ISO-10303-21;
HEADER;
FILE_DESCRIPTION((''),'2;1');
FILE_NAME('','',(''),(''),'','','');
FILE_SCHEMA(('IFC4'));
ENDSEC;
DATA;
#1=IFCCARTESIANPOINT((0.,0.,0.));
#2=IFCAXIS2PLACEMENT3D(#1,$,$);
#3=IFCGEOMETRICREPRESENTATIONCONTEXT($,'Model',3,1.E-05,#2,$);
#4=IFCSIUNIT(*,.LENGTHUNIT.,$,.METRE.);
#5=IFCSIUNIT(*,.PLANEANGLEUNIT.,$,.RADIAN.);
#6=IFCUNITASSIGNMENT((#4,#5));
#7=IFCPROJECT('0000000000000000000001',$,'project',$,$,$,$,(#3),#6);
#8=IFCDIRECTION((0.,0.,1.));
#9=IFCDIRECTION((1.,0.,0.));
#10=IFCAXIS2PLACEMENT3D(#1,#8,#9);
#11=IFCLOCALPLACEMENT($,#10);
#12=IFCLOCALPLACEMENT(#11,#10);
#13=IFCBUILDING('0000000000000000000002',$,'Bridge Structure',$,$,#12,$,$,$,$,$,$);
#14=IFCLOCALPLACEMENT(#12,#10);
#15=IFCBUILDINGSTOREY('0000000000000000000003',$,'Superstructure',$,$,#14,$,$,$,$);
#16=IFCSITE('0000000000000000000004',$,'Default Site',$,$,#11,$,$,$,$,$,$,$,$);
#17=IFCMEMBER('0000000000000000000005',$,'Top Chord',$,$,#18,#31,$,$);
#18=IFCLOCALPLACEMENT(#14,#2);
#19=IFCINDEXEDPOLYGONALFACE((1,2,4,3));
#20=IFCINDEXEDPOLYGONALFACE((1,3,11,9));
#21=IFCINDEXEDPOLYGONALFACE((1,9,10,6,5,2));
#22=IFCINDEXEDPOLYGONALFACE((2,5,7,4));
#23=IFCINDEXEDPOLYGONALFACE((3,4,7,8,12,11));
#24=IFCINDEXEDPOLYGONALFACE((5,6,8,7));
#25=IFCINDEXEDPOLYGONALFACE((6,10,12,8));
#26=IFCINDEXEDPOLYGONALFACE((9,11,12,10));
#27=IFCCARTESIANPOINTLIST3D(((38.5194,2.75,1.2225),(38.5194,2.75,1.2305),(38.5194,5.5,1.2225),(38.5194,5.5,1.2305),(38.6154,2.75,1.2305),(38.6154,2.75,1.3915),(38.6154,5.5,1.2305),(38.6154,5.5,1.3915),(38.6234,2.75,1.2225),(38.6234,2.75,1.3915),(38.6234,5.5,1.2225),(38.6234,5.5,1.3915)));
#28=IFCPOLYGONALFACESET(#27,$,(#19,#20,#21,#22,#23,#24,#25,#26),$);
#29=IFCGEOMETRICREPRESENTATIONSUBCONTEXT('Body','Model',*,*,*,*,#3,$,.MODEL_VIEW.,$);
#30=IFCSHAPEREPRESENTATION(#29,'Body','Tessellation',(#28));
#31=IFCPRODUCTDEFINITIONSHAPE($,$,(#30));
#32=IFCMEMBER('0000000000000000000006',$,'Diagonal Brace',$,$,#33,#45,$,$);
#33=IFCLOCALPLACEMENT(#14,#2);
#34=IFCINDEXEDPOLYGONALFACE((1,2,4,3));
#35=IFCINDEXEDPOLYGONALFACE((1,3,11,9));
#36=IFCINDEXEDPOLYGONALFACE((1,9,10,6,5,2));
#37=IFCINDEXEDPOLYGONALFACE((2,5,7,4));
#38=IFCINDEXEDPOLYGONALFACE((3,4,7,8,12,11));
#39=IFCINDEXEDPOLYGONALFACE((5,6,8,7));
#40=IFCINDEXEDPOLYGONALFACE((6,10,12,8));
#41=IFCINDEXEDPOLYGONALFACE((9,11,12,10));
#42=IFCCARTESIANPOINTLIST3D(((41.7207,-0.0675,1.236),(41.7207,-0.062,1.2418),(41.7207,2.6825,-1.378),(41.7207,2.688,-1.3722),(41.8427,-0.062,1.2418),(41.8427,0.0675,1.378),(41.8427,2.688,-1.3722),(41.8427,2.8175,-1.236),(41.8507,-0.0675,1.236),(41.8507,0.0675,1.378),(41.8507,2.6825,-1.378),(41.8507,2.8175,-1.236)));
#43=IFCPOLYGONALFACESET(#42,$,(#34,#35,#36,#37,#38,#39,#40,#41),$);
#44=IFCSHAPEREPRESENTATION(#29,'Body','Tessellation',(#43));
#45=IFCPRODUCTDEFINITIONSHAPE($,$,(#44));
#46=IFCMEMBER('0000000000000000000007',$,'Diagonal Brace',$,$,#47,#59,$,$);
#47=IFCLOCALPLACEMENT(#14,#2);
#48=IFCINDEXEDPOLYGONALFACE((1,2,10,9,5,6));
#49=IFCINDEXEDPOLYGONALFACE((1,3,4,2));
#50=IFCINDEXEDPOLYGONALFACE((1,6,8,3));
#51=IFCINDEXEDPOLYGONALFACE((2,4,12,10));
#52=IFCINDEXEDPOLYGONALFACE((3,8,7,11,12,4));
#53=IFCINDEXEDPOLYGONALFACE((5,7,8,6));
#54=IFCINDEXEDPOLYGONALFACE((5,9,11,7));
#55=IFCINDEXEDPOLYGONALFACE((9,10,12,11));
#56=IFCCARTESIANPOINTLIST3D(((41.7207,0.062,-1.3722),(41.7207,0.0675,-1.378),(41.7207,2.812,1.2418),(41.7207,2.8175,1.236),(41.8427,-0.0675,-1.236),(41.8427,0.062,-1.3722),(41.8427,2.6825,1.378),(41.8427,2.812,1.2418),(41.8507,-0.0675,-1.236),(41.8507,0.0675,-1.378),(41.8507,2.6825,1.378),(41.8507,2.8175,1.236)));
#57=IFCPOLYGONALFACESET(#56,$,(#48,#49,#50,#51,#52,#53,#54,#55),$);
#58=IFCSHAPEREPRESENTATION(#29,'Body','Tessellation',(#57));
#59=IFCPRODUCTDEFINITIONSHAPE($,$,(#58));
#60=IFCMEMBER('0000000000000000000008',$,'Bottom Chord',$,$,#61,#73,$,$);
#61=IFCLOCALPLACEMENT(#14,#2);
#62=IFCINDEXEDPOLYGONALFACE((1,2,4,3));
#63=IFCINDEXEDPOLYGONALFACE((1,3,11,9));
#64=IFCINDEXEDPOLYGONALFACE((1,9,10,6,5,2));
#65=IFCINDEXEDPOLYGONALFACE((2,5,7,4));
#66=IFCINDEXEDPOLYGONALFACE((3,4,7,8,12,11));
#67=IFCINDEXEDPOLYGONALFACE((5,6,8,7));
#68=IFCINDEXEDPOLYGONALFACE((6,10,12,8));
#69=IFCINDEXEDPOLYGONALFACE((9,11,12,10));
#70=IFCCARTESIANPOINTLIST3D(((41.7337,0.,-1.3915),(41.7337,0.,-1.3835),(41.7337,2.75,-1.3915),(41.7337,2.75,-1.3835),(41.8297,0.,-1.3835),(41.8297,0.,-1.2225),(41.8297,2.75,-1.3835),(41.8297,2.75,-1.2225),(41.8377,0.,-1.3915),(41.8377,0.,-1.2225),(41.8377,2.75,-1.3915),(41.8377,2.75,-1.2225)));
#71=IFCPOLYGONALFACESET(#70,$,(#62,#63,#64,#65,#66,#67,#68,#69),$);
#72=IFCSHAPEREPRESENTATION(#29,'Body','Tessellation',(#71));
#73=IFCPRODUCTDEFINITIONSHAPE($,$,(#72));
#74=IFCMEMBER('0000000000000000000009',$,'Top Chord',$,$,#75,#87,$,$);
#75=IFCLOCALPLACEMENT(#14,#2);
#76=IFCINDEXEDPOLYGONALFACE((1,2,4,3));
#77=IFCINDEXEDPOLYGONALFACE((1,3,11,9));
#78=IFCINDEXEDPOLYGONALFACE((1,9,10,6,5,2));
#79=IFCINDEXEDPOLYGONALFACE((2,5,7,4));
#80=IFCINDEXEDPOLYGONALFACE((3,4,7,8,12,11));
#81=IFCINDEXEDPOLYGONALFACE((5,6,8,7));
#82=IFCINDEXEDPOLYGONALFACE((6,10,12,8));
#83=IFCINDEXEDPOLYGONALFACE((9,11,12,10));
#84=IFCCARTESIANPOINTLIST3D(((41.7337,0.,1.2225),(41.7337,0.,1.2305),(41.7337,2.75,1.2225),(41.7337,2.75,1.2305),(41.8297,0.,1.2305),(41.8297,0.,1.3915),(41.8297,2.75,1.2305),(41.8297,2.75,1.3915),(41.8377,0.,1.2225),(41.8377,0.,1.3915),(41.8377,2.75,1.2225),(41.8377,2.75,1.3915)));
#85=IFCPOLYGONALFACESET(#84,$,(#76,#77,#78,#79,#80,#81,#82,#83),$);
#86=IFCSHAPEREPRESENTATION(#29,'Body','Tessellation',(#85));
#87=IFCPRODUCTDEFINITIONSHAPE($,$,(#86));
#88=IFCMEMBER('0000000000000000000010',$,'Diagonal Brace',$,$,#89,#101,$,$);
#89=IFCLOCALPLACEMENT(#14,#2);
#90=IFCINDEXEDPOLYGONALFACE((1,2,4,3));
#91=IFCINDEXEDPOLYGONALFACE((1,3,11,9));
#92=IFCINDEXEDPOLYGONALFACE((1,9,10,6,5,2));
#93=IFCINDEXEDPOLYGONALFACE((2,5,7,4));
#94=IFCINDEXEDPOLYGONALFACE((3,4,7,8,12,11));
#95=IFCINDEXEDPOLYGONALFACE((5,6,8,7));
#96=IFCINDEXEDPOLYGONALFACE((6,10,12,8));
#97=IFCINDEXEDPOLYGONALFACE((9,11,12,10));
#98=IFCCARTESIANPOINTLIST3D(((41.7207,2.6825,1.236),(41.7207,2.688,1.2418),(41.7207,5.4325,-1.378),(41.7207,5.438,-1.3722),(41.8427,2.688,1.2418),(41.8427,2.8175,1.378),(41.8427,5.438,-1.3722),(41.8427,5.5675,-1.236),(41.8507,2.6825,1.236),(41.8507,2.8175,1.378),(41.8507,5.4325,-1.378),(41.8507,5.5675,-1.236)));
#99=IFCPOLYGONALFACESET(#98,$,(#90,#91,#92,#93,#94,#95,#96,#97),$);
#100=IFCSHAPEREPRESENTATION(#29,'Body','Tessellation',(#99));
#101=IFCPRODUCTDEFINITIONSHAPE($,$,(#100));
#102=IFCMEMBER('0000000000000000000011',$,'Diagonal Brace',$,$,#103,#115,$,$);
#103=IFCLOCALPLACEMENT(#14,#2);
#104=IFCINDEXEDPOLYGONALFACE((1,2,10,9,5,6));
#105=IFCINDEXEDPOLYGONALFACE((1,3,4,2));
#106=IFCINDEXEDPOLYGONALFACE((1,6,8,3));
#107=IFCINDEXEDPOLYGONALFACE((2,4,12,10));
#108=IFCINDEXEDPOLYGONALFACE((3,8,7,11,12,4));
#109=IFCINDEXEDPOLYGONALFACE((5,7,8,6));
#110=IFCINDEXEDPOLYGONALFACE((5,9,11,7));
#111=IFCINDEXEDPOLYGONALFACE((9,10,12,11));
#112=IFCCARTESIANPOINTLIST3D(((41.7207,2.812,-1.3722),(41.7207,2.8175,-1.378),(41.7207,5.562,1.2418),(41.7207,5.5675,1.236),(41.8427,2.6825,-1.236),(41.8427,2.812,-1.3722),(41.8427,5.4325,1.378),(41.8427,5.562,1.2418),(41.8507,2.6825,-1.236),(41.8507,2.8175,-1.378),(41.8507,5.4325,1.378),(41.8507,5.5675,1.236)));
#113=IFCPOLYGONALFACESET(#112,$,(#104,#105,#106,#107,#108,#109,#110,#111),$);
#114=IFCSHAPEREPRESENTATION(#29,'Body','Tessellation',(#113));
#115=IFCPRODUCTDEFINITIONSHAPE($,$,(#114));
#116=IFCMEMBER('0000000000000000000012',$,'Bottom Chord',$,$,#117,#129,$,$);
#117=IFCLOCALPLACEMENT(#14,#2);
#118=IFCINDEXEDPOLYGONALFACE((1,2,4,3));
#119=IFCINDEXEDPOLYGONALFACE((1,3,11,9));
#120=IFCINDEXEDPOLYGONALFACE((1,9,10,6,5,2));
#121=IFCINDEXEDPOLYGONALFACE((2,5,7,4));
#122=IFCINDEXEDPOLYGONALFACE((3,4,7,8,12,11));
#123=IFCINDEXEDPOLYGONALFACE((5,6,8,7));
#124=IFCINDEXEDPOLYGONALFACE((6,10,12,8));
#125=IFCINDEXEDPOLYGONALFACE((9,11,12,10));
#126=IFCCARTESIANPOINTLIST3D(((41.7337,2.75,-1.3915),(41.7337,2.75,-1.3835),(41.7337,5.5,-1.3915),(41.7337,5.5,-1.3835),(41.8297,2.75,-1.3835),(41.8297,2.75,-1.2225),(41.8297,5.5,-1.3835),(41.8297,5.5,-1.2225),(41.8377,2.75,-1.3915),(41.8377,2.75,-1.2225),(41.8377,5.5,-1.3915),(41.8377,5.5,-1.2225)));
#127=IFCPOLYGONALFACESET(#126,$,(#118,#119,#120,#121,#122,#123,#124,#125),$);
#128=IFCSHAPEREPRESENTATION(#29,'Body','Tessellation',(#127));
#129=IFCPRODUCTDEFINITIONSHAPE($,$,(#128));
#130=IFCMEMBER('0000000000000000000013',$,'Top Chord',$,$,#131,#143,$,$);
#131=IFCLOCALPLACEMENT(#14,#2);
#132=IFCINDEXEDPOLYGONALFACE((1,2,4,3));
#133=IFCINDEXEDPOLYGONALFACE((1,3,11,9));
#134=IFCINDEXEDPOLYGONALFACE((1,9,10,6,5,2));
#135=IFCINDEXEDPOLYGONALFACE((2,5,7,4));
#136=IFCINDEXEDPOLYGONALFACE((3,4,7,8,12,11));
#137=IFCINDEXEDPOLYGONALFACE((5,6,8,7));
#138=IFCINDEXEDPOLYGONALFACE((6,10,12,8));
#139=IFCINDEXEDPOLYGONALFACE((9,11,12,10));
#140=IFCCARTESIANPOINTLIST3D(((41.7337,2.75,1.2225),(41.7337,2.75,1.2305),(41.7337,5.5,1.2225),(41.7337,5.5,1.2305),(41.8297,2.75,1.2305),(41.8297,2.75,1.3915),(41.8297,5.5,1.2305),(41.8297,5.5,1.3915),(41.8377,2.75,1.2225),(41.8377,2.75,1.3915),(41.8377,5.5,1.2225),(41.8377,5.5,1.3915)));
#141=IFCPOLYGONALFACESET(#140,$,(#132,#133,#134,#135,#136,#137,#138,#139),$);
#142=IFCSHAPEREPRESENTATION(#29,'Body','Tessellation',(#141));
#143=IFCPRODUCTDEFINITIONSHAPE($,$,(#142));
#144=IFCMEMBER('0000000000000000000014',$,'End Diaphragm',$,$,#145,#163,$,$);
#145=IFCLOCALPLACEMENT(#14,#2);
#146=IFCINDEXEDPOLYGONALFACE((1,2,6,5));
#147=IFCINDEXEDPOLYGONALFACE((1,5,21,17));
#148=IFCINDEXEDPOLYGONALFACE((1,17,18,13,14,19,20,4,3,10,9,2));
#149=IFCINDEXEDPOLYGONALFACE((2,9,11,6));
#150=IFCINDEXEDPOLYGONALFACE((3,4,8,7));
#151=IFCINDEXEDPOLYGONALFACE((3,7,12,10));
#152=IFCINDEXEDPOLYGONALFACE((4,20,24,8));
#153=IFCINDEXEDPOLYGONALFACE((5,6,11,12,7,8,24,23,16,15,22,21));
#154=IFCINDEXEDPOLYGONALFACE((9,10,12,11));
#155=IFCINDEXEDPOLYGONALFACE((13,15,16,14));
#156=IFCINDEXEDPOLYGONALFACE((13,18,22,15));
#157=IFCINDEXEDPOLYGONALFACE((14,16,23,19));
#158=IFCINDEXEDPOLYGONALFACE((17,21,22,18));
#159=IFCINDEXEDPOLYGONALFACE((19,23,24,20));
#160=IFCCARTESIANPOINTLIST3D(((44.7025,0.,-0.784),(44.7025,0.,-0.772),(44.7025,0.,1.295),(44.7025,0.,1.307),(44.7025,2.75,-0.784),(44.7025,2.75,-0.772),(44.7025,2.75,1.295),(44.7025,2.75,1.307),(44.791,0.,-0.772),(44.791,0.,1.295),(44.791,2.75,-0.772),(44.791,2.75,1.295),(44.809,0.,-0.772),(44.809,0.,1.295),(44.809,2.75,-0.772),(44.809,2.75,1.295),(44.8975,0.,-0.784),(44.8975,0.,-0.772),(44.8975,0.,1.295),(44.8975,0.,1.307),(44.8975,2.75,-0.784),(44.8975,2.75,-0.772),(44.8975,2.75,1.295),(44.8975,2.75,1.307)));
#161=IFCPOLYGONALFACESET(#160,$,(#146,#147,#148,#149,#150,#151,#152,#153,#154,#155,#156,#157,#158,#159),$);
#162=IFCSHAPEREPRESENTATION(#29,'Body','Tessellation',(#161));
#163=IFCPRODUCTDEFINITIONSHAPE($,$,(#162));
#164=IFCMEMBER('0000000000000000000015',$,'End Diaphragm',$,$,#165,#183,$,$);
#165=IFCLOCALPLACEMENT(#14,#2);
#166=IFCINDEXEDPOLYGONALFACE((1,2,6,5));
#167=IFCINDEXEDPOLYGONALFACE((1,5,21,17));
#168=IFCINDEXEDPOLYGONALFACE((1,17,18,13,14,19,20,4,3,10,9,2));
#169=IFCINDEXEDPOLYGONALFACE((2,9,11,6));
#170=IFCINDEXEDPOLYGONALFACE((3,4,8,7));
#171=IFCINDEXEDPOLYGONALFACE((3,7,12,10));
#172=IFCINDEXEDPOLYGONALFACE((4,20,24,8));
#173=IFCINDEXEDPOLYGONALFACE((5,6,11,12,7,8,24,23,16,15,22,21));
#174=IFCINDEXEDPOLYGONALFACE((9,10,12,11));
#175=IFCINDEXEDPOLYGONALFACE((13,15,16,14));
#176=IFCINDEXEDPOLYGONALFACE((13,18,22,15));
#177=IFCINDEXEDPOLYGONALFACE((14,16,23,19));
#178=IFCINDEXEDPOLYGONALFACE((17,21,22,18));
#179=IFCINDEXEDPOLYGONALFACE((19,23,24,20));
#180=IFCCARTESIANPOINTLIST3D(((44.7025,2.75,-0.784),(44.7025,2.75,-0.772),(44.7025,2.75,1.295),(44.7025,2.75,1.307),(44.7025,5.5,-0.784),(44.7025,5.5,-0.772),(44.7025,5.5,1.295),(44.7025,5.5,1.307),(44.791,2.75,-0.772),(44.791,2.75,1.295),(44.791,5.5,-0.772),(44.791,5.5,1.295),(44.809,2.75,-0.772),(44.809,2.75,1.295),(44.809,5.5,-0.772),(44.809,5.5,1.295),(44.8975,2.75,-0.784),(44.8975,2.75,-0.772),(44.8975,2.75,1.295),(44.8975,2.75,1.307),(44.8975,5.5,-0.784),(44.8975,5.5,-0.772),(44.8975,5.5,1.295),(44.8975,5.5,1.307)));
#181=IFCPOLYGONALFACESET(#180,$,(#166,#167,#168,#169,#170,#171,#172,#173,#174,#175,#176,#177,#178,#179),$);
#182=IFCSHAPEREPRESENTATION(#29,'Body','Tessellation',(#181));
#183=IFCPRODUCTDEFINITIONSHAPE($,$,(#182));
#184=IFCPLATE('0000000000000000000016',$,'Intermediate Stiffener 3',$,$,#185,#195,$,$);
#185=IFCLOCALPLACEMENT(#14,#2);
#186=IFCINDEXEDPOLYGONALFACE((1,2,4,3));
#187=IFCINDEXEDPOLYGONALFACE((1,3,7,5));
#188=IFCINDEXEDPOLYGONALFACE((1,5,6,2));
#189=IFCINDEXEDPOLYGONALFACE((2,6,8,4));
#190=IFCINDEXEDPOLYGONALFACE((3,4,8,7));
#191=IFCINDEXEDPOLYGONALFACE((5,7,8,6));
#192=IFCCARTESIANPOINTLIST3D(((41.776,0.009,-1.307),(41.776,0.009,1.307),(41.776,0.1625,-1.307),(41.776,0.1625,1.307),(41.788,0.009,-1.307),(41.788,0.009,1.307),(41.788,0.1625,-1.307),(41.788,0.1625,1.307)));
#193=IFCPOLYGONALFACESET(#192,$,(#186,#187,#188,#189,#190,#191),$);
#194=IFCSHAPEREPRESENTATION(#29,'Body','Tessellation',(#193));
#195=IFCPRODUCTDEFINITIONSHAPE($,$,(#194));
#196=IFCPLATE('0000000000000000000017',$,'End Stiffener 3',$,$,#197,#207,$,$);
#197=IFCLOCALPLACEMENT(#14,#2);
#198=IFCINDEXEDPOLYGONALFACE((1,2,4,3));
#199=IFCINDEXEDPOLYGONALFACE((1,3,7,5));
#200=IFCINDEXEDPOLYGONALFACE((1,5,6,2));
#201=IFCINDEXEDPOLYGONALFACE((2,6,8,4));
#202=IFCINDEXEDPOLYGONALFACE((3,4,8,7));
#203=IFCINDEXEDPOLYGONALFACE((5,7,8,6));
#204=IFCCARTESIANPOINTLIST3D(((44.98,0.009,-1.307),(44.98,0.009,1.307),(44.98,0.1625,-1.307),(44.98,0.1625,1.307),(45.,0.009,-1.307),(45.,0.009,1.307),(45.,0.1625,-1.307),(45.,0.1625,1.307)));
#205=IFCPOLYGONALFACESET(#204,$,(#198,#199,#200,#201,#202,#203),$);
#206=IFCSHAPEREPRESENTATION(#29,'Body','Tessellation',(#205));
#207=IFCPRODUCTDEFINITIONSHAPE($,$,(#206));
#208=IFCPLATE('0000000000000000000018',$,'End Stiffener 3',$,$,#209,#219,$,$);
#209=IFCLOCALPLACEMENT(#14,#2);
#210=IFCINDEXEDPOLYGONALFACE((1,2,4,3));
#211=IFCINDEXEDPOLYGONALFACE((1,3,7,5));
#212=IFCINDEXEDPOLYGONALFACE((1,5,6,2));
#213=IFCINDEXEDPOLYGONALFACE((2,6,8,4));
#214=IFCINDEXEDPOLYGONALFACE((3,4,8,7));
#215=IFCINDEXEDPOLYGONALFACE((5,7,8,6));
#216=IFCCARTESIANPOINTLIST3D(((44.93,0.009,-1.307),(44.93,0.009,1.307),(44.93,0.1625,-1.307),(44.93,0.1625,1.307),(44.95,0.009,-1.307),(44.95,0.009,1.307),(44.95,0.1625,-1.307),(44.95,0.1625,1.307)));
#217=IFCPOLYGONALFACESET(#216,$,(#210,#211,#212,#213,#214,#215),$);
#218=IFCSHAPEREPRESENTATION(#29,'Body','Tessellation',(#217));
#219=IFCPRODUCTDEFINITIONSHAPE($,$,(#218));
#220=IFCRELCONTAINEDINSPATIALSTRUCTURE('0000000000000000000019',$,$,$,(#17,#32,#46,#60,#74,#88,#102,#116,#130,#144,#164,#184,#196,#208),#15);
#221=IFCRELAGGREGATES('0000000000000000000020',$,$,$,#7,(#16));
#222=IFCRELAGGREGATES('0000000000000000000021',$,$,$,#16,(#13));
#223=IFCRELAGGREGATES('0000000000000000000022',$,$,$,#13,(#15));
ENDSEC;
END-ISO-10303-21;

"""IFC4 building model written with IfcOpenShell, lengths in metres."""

from ifc_helpers import new_model, si_unit, frame, origin, origin_with_axes, origin_2d_with_axis, place, context, subcontext, project, spatial, rectangle, i_section, l_section, extrude, element, save


model = new_model("IFC4")

# Units and contexts
model_context = context("Model", 3, precision=1e-05, world=origin())
body_context = subcontext(model_context, "Body", "Model", "MODEL_VIEW")
ifc_project = project(units=[si_unit("LENGTHUNIT", "METRE"), si_unit("PLANEANGLEUNIT", "RADIAN")], contexts=[model_context])

# Site, building, storey
site_placement = place(None, origin_with_axes())
site = spatial("IfcSite", under=ifc_project, at=site_placement, Name="Default Site")
building_placement = place(site_placement, origin_with_axes())
building = spatial("IfcBuilding", under=site, at=building_placement, Name="Bridge Structure")
storey_placement = place(building_placement, origin_with_axes())
storey = spatial("IfcBuildingStorey", under=building, at=storey_placement, Name="Superstructure")

# Members
member_placement = place(storey_placement, frame((38.5714, 2.75, 1.307), z_axis=(0.0, 1.0, 0.0), x_axis=(-1.0, 0.0, 0.0)))
element("IfcMember", 1, at=member_placement, inside=storey, Name="Top Chord", context=body_context, shape_type="SweptSolid", body=[
    extrude(l_section(Depth=0.169, Width=0.104, Thickness=0.008, at=origin_2d_with_axis()), origin_with_axes(), (0.0, 0.0, 1.0), 2.75),
])
for number, where, z_axis, x_axis, name in (
    (2, (41.7857, 0.0, 1.307), (0.0, 0.724802, -0.688957), (-1.0, 0.0, 0.0), "Diagonal Brace"),
    (3, (41.7857, 0.0, -1.307), (0.0, 0.724802, 0.688957), (-1.0, 0.0, 0.0), "Diagonal Brace"),
):
    element("IfcMember", number, at=place(storey_placement, frame(where, z_axis=z_axis, x_axis=x_axis)), inside=storey, Name=name, context=body_context, shape_type="SweptSolid", body=[
        extrude(l_section(Depth=0.196, Width=0.13, Thickness=0.008, at=origin_2d_with_axis()), origin_with_axes(), (0.0, 0.0, 1.0), 3.7941),
    ])
for number, where, z_axis, x_axis, name in (
    (4, (41.7857, 0.0, -1.307), (0.0, 1.0, 0.0), (-1.0, 0.0, 0.0), "Bottom Chord"),
    (5, (41.7857, 0.0, 1.307), (0.0, 1.0, 0.0), (-1.0, 0.0, 0.0), "Top Chord"),
):
    element("IfcMember", number, at=place(storey_placement, frame(where, z_axis=z_axis, x_axis=x_axis)), inside=storey, Name=name, context=body_context, shape_type="SweptSolid", body=[
        extrude(l_section(Depth=0.169, Width=0.104, Thickness=0.008, at=origin_2d_with_axis()), origin_with_axes(), (0.0, 0.0, 1.0), 2.75),
    ])
for number, where, z_axis, x_axis, name in (
    (6, (41.7857, 2.75, 1.307), (0.0, 0.724802, -0.688957), (-1.0, 0.0, 0.0), "Diagonal Brace"),
    (7, (41.7857, 2.75, -1.307), (0.0, 0.724802, 0.688957), (-1.0, 0.0, 0.0), "Diagonal Brace"),
):
    element("IfcMember", number, at=place(storey_placement, frame(where, z_axis=z_axis, x_axis=x_axis)), inside=storey, Name=name, context=body_context, shape_type="SweptSolid", body=[
        extrude(l_section(Depth=0.196, Width=0.13, Thickness=0.008, at=origin_2d_with_axis()), origin_with_axes(), (0.0, 0.0, 1.0), 3.7941),
    ])
for number, where, z_axis, x_axis, name in (
    (8, (41.7857, 2.75, -1.307), (0.0, 1.0, 0.0), (-1.0, 0.0, 0.0), "Bottom Chord"),
    (9, (41.7857, 2.75, 1.307), (0.0, 1.0, 0.0), (-1.0, 0.0, 0.0), "Top Chord"),
):
    element("IfcMember", number, at=place(storey_placement, frame(where, z_axis=z_axis, x_axis=x_axis)), inside=storey, Name=name, context=body_context, shape_type="SweptSolid", body=[
        extrude(l_section(Depth=0.169, Width=0.104, Thickness=0.008, at=origin_2d_with_axis()), origin_with_axes(), (0.0, 0.0, 1.0), 2.75),
    ])
for number, where, z_axis, x_axis, name in (
    (10, (44.8, 0.0, 0.2615), (0.0, 1.0, 0.0), (-1.0, 0.0, 0.0), "End Diaphragm"),
    (11, (44.8, 2.75, 0.2615), (0.0, 1.0, 0.0), (-1.0, 0.0, 0.0), "End Diaphragm"),
):
    element("IfcMember", number, at=place(storey_placement, frame(where, z_axis=z_axis, x_axis=x_axis)), inside=storey, Name=name, context=body_context, shape_type="SweptSolid", body=[
        extrude(i_section(OverallWidth=0.195, OverallDepth=2.091, WebThickness=0.018, FlangeThickness=0.012, at=origin_2d_with_axis()), origin_with_axes(), (0.0, 0.0, 1.0), 2.75),
    ])

# Plates
plate_placement = place(storey_placement, frame((41.782, 0.0858, -1.307), z_axis=(0.0, 0.0, 1.0), x_axis=(1.0, 0.0, 0.0)))
element("IfcPlate", 12, at=plate_placement, inside=storey, Name="Intermediate Stiffener 3", context=body_context, shape_type="SweptSolid", body=[
    extrude(rectangle(XDim=0.012, YDim=0.1535, at=origin_2d_with_axis()), origin_with_axes(), (0.0, 0.0, 1.0), 2.614),
])
for number, where, z_axis, x_axis, name in (
    (13, (44.99, 0.0858, -1.307), (0.0, 0.0, 1.0), (1.0, 0.0, 0.0), "End Stiffener 3"),
    (14, (44.94, 0.0858, -1.307), (0.0, 0.0, 1.0), (1.0, 0.0, 0.0), "End Stiffener 3"),
):
    element("IfcPlate", number, at=place(storey_placement, frame(where, z_axis=z_axis, x_axis=x_axis)), inside=storey, Name=name, context=body_context, shape_type="SweptSolid", body=[
        extrude(rectangle(XDim=0.02, YDim=0.1535, at=origin_2d_with_axis()), origin_with_axes(), (0.0, 0.0, 1.0), 2.614),
    ])

save(model, "model.ifc")
